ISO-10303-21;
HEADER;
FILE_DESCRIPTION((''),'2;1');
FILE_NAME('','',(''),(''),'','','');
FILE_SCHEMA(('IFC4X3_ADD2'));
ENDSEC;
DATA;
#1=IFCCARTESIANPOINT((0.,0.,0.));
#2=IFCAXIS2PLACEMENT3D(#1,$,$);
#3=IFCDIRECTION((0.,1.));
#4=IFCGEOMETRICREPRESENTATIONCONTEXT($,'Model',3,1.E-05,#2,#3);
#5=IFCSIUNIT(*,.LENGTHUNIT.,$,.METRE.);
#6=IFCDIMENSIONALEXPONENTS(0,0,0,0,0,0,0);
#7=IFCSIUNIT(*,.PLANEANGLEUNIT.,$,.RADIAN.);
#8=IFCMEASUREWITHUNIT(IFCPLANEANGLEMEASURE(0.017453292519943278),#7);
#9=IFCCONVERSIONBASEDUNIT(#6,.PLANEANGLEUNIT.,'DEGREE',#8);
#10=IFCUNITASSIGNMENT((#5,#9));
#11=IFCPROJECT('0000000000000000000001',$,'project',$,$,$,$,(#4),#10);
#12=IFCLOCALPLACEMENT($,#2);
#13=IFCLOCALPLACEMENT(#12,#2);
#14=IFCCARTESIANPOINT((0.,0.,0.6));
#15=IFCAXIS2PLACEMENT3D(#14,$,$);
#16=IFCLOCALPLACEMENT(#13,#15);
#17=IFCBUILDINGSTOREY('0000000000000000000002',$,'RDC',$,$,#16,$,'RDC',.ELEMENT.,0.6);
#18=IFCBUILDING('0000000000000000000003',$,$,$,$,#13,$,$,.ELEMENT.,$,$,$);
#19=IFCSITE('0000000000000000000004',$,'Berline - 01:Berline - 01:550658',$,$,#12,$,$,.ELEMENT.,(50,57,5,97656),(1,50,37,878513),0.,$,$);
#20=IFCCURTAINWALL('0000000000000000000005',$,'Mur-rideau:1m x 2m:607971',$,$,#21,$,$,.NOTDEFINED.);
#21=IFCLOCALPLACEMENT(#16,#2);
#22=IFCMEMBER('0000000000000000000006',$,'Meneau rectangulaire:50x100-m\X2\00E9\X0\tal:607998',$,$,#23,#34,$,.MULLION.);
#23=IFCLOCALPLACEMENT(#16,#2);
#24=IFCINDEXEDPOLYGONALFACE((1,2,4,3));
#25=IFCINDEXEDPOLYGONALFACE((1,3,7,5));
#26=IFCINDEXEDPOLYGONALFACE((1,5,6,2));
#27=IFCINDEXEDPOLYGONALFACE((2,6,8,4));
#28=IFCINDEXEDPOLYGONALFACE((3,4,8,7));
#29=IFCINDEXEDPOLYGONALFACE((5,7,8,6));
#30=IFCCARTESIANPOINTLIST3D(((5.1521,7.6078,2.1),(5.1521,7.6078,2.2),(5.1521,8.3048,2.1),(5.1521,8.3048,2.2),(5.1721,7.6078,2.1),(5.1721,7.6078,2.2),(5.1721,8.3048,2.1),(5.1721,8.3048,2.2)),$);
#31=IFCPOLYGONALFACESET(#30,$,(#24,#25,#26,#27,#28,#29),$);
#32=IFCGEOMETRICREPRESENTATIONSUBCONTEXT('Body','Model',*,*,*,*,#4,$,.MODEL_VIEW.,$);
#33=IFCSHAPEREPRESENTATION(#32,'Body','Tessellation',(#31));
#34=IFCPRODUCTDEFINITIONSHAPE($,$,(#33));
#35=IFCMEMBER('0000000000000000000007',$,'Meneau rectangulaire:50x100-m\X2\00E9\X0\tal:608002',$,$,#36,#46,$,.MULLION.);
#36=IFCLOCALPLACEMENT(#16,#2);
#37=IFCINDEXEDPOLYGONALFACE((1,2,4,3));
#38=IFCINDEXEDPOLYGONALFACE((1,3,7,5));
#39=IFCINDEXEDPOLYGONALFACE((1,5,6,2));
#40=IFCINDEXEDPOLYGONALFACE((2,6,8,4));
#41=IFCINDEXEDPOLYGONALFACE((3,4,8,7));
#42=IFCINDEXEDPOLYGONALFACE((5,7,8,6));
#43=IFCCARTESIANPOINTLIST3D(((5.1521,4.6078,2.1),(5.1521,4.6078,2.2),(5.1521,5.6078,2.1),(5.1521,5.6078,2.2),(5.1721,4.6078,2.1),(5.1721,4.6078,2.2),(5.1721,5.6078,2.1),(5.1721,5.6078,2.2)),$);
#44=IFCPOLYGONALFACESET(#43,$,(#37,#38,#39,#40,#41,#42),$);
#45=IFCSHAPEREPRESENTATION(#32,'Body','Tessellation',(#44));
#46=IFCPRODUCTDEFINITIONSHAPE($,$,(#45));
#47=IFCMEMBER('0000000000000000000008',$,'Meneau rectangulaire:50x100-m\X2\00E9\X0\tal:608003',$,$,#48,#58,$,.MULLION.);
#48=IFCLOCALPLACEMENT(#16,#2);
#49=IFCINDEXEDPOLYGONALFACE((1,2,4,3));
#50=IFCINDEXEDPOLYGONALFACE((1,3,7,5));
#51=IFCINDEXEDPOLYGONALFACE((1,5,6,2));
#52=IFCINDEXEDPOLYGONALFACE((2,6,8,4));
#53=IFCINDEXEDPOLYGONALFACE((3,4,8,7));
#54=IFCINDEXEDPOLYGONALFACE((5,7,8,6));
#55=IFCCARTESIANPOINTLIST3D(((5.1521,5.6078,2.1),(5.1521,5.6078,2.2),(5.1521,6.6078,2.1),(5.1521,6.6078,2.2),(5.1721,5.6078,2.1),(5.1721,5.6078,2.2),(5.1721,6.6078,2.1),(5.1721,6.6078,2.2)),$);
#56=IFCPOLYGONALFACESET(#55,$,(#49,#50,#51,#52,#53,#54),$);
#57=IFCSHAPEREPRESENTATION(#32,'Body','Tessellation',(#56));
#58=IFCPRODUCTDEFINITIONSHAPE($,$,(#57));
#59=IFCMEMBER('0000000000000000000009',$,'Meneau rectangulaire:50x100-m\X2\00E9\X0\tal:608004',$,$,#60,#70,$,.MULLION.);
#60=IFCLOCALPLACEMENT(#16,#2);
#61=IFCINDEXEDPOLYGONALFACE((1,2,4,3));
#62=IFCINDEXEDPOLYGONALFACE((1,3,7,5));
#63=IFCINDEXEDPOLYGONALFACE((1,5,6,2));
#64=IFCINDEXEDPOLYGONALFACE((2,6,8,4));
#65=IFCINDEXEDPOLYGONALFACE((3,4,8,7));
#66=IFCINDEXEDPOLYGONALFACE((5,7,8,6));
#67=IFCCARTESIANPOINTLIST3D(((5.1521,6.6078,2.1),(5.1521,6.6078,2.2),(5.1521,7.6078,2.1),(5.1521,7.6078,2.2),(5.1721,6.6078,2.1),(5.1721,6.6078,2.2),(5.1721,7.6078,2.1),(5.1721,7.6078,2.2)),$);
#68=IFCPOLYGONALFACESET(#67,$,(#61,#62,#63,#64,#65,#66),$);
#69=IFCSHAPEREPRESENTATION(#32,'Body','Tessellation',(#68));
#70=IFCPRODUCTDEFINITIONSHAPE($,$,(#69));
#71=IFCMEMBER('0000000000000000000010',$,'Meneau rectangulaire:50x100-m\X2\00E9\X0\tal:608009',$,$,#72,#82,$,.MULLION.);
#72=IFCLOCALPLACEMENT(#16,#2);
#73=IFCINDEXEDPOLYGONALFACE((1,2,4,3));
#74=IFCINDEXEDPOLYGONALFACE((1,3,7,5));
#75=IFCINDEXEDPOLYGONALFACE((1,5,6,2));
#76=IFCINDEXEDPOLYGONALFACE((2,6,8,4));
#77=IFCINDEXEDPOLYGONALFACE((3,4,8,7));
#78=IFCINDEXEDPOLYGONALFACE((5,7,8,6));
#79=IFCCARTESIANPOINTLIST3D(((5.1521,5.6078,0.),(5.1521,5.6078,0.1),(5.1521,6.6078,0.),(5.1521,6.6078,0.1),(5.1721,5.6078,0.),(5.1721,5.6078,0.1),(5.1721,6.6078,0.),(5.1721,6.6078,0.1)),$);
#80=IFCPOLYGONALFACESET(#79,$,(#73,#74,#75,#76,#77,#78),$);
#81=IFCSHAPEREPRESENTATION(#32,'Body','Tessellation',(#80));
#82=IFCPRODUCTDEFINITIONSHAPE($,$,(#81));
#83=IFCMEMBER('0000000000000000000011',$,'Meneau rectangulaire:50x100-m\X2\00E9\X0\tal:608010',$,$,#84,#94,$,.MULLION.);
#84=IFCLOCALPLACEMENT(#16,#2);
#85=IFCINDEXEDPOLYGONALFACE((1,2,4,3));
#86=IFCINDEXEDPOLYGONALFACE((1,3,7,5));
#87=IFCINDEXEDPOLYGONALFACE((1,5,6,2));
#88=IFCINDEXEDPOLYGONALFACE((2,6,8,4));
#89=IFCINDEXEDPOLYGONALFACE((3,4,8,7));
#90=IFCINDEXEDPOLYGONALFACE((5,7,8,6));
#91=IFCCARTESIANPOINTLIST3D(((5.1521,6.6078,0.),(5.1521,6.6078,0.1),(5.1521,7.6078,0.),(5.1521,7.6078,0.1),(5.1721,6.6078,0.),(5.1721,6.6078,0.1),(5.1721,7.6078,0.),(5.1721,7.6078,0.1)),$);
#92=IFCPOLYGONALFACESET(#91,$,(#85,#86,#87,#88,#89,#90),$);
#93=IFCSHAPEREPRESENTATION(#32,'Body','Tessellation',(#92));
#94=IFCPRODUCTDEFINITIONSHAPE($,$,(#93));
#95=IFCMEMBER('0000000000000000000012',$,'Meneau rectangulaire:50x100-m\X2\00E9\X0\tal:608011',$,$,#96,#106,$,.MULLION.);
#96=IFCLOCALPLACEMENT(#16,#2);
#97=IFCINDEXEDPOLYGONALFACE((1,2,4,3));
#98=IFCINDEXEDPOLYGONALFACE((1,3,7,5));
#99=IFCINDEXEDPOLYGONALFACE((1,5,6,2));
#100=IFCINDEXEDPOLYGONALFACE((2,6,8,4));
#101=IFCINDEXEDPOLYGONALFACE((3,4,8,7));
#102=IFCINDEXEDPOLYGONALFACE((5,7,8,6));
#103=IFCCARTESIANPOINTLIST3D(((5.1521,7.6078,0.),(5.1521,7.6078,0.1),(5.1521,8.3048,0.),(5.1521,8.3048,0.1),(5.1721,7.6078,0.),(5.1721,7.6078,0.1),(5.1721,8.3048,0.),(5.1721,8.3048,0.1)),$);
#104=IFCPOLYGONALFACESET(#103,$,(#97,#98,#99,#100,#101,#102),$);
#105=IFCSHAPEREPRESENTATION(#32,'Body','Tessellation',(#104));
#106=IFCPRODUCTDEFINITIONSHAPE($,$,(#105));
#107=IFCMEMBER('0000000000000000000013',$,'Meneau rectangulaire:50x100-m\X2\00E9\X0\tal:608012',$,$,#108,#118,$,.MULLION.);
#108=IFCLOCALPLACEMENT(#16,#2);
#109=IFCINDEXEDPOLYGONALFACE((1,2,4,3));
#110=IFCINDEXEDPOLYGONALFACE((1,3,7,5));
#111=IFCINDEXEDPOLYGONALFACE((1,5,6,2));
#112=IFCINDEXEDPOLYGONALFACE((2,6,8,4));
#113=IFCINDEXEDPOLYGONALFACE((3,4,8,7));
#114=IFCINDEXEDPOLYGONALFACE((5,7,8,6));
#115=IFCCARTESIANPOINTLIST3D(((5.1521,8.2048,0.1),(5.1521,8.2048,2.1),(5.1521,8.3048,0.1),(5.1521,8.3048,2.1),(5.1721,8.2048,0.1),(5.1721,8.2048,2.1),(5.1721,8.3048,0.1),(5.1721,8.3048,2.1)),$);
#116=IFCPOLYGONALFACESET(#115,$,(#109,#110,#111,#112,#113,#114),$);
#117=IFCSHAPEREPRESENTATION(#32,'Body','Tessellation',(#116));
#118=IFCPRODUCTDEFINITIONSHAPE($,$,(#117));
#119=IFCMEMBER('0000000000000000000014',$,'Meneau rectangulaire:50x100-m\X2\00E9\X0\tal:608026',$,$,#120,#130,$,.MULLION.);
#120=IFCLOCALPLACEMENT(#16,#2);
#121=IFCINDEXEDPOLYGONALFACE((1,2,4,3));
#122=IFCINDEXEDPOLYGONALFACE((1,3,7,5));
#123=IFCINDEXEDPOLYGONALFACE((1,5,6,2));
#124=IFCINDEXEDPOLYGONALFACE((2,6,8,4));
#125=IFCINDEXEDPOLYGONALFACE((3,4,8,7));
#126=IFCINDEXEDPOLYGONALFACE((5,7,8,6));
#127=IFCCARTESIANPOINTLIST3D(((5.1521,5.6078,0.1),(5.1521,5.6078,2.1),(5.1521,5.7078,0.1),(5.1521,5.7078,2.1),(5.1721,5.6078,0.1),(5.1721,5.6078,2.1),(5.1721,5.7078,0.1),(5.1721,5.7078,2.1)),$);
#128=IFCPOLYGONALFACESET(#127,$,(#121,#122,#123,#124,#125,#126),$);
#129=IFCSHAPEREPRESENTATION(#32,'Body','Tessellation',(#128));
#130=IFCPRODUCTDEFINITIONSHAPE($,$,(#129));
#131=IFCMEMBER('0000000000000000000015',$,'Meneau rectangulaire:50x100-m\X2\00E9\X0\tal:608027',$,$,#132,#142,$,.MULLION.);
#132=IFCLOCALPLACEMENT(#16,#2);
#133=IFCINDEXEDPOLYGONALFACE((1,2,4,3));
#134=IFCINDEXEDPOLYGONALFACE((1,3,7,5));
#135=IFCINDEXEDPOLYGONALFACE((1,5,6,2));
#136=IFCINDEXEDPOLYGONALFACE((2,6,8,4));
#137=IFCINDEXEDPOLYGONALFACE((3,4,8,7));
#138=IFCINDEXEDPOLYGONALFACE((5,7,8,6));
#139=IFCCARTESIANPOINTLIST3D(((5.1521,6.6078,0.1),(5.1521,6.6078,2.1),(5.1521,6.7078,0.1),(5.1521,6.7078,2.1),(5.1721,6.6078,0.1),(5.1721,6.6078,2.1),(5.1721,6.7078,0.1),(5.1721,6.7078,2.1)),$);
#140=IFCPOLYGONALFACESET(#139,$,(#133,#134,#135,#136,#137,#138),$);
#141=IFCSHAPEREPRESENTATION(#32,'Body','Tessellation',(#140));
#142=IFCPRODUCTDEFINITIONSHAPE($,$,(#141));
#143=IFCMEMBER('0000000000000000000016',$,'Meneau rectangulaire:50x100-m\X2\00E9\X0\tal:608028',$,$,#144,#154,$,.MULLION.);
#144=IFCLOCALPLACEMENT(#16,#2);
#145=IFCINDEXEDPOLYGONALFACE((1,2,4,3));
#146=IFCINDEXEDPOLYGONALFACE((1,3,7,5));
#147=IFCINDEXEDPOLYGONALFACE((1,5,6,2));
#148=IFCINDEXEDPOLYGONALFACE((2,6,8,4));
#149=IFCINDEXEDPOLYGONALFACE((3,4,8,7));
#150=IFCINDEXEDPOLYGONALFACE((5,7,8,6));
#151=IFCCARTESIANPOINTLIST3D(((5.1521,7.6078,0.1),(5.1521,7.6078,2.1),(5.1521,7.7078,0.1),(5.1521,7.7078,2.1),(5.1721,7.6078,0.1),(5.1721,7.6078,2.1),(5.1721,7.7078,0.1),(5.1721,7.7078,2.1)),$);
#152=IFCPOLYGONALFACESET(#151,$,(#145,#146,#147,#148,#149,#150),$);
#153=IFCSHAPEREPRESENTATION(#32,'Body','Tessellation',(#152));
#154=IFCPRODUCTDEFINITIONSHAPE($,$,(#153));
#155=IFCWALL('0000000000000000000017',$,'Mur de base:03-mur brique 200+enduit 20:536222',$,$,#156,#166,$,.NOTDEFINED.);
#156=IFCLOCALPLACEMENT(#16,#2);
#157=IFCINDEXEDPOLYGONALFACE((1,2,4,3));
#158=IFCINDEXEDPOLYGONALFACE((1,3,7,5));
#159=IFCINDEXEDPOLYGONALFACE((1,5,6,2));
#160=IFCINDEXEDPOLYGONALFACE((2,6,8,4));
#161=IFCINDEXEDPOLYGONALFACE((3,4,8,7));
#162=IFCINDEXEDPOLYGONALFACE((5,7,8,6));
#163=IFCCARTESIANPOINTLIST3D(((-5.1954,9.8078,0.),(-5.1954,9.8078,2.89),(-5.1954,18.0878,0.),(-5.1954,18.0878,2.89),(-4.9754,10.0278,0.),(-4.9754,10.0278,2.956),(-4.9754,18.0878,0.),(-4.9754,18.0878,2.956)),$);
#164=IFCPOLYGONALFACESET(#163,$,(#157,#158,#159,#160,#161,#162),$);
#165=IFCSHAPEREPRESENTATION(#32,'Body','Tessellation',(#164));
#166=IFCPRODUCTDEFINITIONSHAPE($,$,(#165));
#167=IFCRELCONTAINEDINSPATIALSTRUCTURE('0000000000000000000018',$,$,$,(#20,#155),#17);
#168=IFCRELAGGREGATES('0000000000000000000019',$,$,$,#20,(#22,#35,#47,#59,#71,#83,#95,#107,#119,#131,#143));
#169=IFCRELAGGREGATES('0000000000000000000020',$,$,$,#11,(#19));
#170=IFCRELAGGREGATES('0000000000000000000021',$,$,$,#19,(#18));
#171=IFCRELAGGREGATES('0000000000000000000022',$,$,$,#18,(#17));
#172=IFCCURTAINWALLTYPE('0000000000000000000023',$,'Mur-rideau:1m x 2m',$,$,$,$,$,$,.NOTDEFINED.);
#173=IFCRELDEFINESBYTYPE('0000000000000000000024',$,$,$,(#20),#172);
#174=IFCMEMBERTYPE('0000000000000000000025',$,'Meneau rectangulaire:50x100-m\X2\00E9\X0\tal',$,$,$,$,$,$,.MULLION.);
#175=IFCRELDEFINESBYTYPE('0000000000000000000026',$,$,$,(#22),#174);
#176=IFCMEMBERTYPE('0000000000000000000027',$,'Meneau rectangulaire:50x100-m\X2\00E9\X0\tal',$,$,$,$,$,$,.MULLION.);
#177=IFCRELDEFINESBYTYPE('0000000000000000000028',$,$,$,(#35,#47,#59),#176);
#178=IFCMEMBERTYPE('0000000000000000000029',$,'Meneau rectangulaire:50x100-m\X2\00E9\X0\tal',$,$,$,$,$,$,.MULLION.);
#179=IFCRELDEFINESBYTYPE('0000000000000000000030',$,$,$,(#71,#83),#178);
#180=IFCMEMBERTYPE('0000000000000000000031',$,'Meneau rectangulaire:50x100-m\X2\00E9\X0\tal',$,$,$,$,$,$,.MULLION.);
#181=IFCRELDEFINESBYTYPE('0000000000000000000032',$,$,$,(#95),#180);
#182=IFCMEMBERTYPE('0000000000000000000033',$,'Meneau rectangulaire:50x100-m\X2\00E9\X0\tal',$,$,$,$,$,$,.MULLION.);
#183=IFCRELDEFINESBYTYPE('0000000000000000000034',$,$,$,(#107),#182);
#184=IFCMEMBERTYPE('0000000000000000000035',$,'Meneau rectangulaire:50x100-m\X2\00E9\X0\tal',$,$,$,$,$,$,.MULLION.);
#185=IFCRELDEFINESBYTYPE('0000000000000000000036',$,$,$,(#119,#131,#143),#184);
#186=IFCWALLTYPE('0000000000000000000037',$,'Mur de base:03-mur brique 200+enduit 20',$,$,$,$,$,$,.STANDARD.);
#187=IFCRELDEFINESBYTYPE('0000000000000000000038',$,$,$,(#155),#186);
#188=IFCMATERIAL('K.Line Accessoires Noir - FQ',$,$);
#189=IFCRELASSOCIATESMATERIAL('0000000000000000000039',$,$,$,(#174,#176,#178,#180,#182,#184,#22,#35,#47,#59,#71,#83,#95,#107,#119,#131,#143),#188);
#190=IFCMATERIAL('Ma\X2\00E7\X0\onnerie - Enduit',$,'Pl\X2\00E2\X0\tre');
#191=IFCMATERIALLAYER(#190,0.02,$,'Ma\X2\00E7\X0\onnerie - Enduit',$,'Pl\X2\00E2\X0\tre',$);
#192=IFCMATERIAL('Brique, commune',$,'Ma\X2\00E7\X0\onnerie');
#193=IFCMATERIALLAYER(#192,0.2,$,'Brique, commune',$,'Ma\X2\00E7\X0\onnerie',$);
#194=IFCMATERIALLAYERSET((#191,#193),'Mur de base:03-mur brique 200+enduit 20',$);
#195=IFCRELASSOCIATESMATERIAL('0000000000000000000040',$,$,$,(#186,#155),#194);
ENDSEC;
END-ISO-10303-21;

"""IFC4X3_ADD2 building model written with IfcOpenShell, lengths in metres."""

from ifc_helpers import new_model, entity, si_unit, converted_unit, direction, frame, origin, origin_2d_with_axis, place, context, subcontext, project, spatial, polyline, rectangle, outline, extrude, clip, bounded_halfspace, source, transform, mapped, material, layer, layer_set, material_profile, profile_set, profile_usage, type_object, type_shapes, element, aggregate, save


model = new_model("IFC4X3_ADD2")

# Units and contexts
model_context = context("Model", 3, precision=1e-05, world=origin(), true_north=direction((0.0, 1.0)))
body_context = subcontext(model_context, "Body", "Model", "MODEL_VIEW")
ifc_project = project(units=[si_unit("LENGTHUNIT", "METRE"), converted_unit("PLANEANGLEUNIT", "DEGREE", entity("IfcPlaneAngleMeasure", 0.017453292519943278), si_unit("PLANEANGLEUNIT", "RADIAN"), dimensions=[0, 0, 0, 0, 0, 0, 0])], contexts=[model_context])

# Site, building, storey
site_placement = place(None, origin())
site = spatial("IfcSite", under=ifc_project, at=site_placement, Name="Berline - 01:Berline - 01:550658", CompositionType="ELEMENT", RefLatitude=(50, 57, 5, 97656), RefLongitude=(1, 50, 37, 878513), RefElevation=0.0)
building_placement = place(site_placement, origin())
building = spatial("IfcBuilding", under=site, at=building_placement, CompositionType="ELEMENT")
storey_placement = place(building_placement, frame((0.0, 0.0, 0.6)))
storey = spatial("IfcBuildingStorey", under=building, at=storey_placement, Name="RDC", LongName="RDC", CompositionType="ELEMENT", Elevation=0.6)

# Curtain wall, members
curtain_wall_type = type_object("IfcCurtainWallType", Name="Mur-rideau:1m x 2m", PredefinedType="NOTDEFINED")
curtain_wall_placement = place(storey_placement, frame((0.0, 0.0, -0.6)))
curtain_wall = element("IfcCurtainWall", 1, at=curtain_wall_placement, inside=storey, type_object=curtain_wall_type, Name="Mur-rideau:1m x 2m:607971", PredefinedType="NOTDEFINED")
ifc_material_1 = material(Name="K.Line Accessoires Noir - FQ")
ifc_material_profile = material_profile(ifc_material_1, rectangle(XDim=0.1, YDim=0.02, at=origin_2d_with_axis()), Name="50x100-métal")
ifc_profile_set = profile_set([ifc_material_profile], Name="50x100-métal")
ifc_profile_usage = profile_usage(ifc_profile_set)
member_type_1 = type_object("IfcMemberType", Name="Meneau rectangulaire:50x100-métal", PredefinedType="MULLION", material=ifc_profile_set)
shared_shape_1 = source(origin(), body_context, "Body", "SweptSolid", [
    extrude(rectangle(XDim=0.02, YDim=0.1, at=origin_2d_with_axis()), frame((-0.05, -0.01, -0.697), z_axis=(0.0, 0.0, 1.0), x_axis=(0.0, 1.0, 0.0)), (0.0, 0.0, 1.0), 0.697),
])
type_shapes(member_type_1, [shared_shape_1])
member_1_placement = place(curtain_wall_placement, frame((5.1721, 8.3048, 2.8), z_axis=(0.0, 1.0, 0.0), x_axis=(0.0, 0.0, 1.0)))
member_1 = element("IfcMember", 2, at=member_1_placement, type_object=member_type_1, material=ifc_profile_usage, Name="Meneau rectangulaire:50x100-métal:607998", PredefinedType="MULLION", context=body_context, shape_type="MappedRepresentation", body=[
    mapped(shared_shape_1, transform((0.0, 0.0, 0.0), scale=1.0)),
])
member_type_2 = type_object("IfcMemberType", Name="Meneau rectangulaire:50x100-métal", PredefinedType="MULLION", material=ifc_profile_set)
shared_shape_2 = source(origin(), body_context, "Body", "SweptSolid", [
    extrude(rectangle(XDim=0.02, YDim=0.1, at=origin_2d_with_axis()), frame((-0.05, -0.01, -1.0), z_axis=(0.0, 0.0, 1.0), x_axis=(0.0, 1.0, 0.0)), (0.0, 0.0, 1.0), 1.0),
])
type_shapes(member_type_2, [shared_shape_2])
member_2_placement = place(curtain_wall_placement, frame((5.1721, 5.6078, 2.8), z_axis=(0.0, 1.0, 0.0), x_axis=(0.0, 0.0, 1.0)))
member_2 = element("IfcMember", 3, at=member_2_placement, type_object=member_type_2, material=ifc_profile_usage, Name="Meneau rectangulaire:50x100-métal:608002", PredefinedType="MULLION", context=body_context, shape_type="MappedRepresentation", body=[
    mapped(shared_shape_2, transform((0.0, 0.0, 0.0), scale=1.0)),
])
member_3_placement = place(curtain_wall_placement, frame((5.1721, 6.6078, 2.8), z_axis=(0.0, 1.0, 0.0), x_axis=(0.0, 0.0, 1.0)))
member_3 = element("IfcMember", 4, at=member_3_placement, type_object=member_type_2, material=ifc_profile_usage, Name="Meneau rectangulaire:50x100-métal:608003", PredefinedType="MULLION", context=body_context, shape_type="MappedRepresentation", body=[
    mapped(shared_shape_2, transform((0.0, 0.0, 0.0), scale=1.0)),
])
member_4_placement = place(curtain_wall_placement, frame((5.1721, 7.6078, 2.8), z_axis=(0.0, 1.0, 0.0), x_axis=(0.0, 0.0, 1.0)))
member_4 = element("IfcMember", 5, at=member_4_placement, type_object=member_type_2, material=ifc_profile_usage, Name="Meneau rectangulaire:50x100-métal:608004", PredefinedType="MULLION", context=body_context, shape_type="MappedRepresentation", body=[
    mapped(shared_shape_2, transform((0.0, 0.0, 0.0), scale=1.0)),
])
member_type_3 = type_object("IfcMemberType", Name="Meneau rectangulaire:50x100-métal", PredefinedType="MULLION", material=ifc_profile_set)
shared_shape_3 = source(origin(), body_context, "Body", "SweptSolid", [
    extrude(rectangle(XDim=0.1, YDim=0.02, at=origin_2d_with_axis()), frame((-0.05, -0.01, -1.0)), (0.0, 0.0, 1.0), 1.0),
])
type_shapes(member_type_3, [shared_shape_3])
member_5_placement = place(curtain_wall_placement, frame((5.1721, 5.6078, 0.6), z_axis=(0.0, -1.0, 0.0), x_axis=(0.0, 0.0, -1.0)))
member_5 = element("IfcMember", 6, at=member_5_placement, type_object=member_type_3, material=ifc_profile_usage, Name="Meneau rectangulaire:50x100-métal:608009", PredefinedType="MULLION", context=body_context, shape_type="MappedRepresentation", body=[
    mapped(shared_shape_3, transform((0.0, 0.0, 0.0), scale=1.0)),
])
member_6_placement = place(curtain_wall_placement, frame((5.1721, 6.6078, 0.6), z_axis=(0.0, -1.0, 0.0), x_axis=(0.0, 0.0, -1.0)))
member_6 = element("IfcMember", 7, at=member_6_placement, type_object=member_type_3, material=ifc_profile_usage, Name="Meneau rectangulaire:50x100-métal:608010", PredefinedType="MULLION", context=body_context, shape_type="MappedRepresentation", body=[
    mapped(shared_shape_3, transform((0.0, 0.0, 0.0), scale=1.0)),
])
member_type_4 = type_object("IfcMemberType", Name="Meneau rectangulaire:50x100-métal", PredefinedType="MULLION", material=ifc_profile_set)
shared_shape_4 = source(origin(), body_context, "Body", "SweptSolid", [
    extrude(rectangle(XDim=0.1, YDim=0.02, at=origin_2d_with_axis()), frame((-0.05, -0.01, -0.697)), (0.0, 0.0, 1.0), 0.697),
])
type_shapes(member_type_4, [shared_shape_4])
member_7_placement = place(curtain_wall_placement, frame((5.1721, 7.6078, 0.6), z_axis=(0.0, -1.0, 0.0), x_axis=(0.0, 0.0, -1.0)))
member_7 = element("IfcMember", 8, at=member_7_placement, type_object=member_type_4, material=ifc_profile_usage, Name="Meneau rectangulaire:50x100-métal:608011", PredefinedType="MULLION", context=body_context, shape_type="MappedRepresentation", body=[
    mapped(shared_shape_4, transform((0.0, 0.0, 0.0), scale=1.0)),
])
member_type_5 = type_object("IfcMemberType", Name="Meneau rectangulaire:50x100-métal", PredefinedType="MULLION", material=ifc_profile_set)
shared_shape_5 = source(origin(), body_context, "Body", "SweptSolid", [
    extrude(rectangle(XDim=0.02, YDim=0.1, at=origin_2d_with_axis()), frame((-0.05, -0.01, -2.0), z_axis=(0.0, 0.0, 1.0), x_axis=(0.0, 1.0, 0.0)), (0.0, 0.0, 1.0), 2.0),
])
type_shapes(member_type_5, [shared_shape_5])
member_8_placement = place(curtain_wall_placement, frame((5.1721, 8.3048, 0.7), z_axis=(0.0, 0.0, -1.0), x_axis=(0.0, 1.0, 0.0)))
member_8 = element("IfcMember", 9, at=member_8_placement, type_object=member_type_5, material=ifc_profile_usage, Name="Meneau rectangulaire:50x100-métal:608012", PredefinedType="MULLION", context=body_context, shape_type="MappedRepresentation", body=[
    mapped(shared_shape_5, transform((0.0, 0.0, 0.0), scale=1.0)),
])
member_type_6 = type_object("IfcMemberType", Name="Meneau rectangulaire:50x100-métal", PredefinedType="MULLION", material=ifc_profile_set)
shared_shape_6 = source(origin(), body_context, "Body", "SweptSolid", [
    extrude(rectangle(XDim=0.02, YDim=0.1, at=origin_2d_with_axis()), frame((0.05, -0.01, -2.0), z_axis=(0.0, 0.0, 1.0), x_axis=(0.0, 1.0, 0.0)), (0.0, 0.0, 1.0), 2.0),
])
type_shapes(member_type_6, [shared_shape_6])
member_9_placement = place(curtain_wall_placement, frame((5.1721, 5.6078, 0.7), z_axis=(0.0, 0.0, -1.0), x_axis=(0.0, 1.0, 0.0)))
member_9 = element("IfcMember", 10, at=member_9_placement, type_object=member_type_6, material=ifc_profile_usage, Name="Meneau rectangulaire:50x100-métal:608026", PredefinedType="MULLION", context=body_context, shape_type="MappedRepresentation", body=[
    mapped(shared_shape_6, transform((0.0, 0.0, 0.0), scale=1.0)),
])
member_10_placement = place(curtain_wall_placement, frame((5.1721, 6.6078, 0.7), z_axis=(0.0, 0.0, -1.0), x_axis=(0.0, 1.0, 0.0)))
member_10 = element("IfcMember", 11, at=member_10_placement, type_object=member_type_6, material=ifc_profile_usage, Name="Meneau rectangulaire:50x100-métal:608027", PredefinedType="MULLION", context=body_context, shape_type="MappedRepresentation", body=[
    mapped(shared_shape_6, transform((0.0, 0.0, 0.0), scale=1.0)),
])
member_11_placement = place(curtain_wall_placement, frame((5.1721, 7.6078, 0.7), z_axis=(0.0, 0.0, -1.0), x_axis=(0.0, 1.0, 0.0)))
member_11 = element("IfcMember", 12, at=member_11_placement, type_object=member_type_6, material=ifc_profile_usage, Name="Meneau rectangulaire:50x100-métal:608028", PredefinedType="MULLION", context=body_context, shape_type="MappedRepresentation", body=[
    mapped(shared_shape_6, transform((0.0, 0.0, 0.0), scale=1.0)),
])
aggregate(curtain_wall, [member_1, member_2, member_3, member_4, member_5, member_6, member_7, member_8, member_9, member_10, member_11])

# Wall
ifc_material_2 = material(Name="Maçonnerie - Enduit", Category="Plâtre")
ifc_layer_1 = layer(ifc_material_2, 0.02, Name="Maçonnerie - Enduit", Category="Plâtre")
ifc_material_3 = material(Name="Brique, commune", Category="Maçonnerie")
ifc_layer_2 = layer(ifc_material_3, 0.2, Name="Brique, commune", Category="Maçonnerie")
ifc_layer_set_1 = layer_set([ifc_layer_1, ifc_layer_2], Name="Mur de base:03-mur brique 200+enduit 20")
wall_type_1 = type_object("IfcWallType", Name="Mur de base:03-mur brique 200+enduit 20", PredefinedType="STANDARD", material=ifc_layer_set_1)
wall_1_placement = place(storey_placement, frame((-5.0854, 9.8078, 0.0), z_axis=(0.0, 0.0, 1.0), x_axis=(0.0, 1.0, 0.0)))
element("IfcWall", 13, at=wall_1_placement, inside=storey, type_object=wall_type_1, material=ifc_layer_set_1, Name="Mur de base:03-mur brique 200+enduit 20:536222", PredefinedType="NOTDEFINED", context=body_context, shape_type="Clipping", body=[
    clip(extrude(outline(polyline([(8.28, -0.11), (8.28, 0.11), (0.0, 0.11), (0.22, -0.11), (0.3525, -0.11), (8.28, -0.11)])), origin(), (0.0, 0.0, 1.0), 2.956), bounded_halfspace(frame((0.22, -0.11, 2.956), z_axis=(0.0, 0.287361, 0.957822), x_axis=(-1.0, 0.0, 0.0)), False, frame((0.22, -0.11, 2.956)), polyline([(0.0, 0.0), (8.06, 0.0), (8.06, 0.22), (-0.22, 0.22), (0.0, 0.0)]))),
])

save(model, "model.ifc")
